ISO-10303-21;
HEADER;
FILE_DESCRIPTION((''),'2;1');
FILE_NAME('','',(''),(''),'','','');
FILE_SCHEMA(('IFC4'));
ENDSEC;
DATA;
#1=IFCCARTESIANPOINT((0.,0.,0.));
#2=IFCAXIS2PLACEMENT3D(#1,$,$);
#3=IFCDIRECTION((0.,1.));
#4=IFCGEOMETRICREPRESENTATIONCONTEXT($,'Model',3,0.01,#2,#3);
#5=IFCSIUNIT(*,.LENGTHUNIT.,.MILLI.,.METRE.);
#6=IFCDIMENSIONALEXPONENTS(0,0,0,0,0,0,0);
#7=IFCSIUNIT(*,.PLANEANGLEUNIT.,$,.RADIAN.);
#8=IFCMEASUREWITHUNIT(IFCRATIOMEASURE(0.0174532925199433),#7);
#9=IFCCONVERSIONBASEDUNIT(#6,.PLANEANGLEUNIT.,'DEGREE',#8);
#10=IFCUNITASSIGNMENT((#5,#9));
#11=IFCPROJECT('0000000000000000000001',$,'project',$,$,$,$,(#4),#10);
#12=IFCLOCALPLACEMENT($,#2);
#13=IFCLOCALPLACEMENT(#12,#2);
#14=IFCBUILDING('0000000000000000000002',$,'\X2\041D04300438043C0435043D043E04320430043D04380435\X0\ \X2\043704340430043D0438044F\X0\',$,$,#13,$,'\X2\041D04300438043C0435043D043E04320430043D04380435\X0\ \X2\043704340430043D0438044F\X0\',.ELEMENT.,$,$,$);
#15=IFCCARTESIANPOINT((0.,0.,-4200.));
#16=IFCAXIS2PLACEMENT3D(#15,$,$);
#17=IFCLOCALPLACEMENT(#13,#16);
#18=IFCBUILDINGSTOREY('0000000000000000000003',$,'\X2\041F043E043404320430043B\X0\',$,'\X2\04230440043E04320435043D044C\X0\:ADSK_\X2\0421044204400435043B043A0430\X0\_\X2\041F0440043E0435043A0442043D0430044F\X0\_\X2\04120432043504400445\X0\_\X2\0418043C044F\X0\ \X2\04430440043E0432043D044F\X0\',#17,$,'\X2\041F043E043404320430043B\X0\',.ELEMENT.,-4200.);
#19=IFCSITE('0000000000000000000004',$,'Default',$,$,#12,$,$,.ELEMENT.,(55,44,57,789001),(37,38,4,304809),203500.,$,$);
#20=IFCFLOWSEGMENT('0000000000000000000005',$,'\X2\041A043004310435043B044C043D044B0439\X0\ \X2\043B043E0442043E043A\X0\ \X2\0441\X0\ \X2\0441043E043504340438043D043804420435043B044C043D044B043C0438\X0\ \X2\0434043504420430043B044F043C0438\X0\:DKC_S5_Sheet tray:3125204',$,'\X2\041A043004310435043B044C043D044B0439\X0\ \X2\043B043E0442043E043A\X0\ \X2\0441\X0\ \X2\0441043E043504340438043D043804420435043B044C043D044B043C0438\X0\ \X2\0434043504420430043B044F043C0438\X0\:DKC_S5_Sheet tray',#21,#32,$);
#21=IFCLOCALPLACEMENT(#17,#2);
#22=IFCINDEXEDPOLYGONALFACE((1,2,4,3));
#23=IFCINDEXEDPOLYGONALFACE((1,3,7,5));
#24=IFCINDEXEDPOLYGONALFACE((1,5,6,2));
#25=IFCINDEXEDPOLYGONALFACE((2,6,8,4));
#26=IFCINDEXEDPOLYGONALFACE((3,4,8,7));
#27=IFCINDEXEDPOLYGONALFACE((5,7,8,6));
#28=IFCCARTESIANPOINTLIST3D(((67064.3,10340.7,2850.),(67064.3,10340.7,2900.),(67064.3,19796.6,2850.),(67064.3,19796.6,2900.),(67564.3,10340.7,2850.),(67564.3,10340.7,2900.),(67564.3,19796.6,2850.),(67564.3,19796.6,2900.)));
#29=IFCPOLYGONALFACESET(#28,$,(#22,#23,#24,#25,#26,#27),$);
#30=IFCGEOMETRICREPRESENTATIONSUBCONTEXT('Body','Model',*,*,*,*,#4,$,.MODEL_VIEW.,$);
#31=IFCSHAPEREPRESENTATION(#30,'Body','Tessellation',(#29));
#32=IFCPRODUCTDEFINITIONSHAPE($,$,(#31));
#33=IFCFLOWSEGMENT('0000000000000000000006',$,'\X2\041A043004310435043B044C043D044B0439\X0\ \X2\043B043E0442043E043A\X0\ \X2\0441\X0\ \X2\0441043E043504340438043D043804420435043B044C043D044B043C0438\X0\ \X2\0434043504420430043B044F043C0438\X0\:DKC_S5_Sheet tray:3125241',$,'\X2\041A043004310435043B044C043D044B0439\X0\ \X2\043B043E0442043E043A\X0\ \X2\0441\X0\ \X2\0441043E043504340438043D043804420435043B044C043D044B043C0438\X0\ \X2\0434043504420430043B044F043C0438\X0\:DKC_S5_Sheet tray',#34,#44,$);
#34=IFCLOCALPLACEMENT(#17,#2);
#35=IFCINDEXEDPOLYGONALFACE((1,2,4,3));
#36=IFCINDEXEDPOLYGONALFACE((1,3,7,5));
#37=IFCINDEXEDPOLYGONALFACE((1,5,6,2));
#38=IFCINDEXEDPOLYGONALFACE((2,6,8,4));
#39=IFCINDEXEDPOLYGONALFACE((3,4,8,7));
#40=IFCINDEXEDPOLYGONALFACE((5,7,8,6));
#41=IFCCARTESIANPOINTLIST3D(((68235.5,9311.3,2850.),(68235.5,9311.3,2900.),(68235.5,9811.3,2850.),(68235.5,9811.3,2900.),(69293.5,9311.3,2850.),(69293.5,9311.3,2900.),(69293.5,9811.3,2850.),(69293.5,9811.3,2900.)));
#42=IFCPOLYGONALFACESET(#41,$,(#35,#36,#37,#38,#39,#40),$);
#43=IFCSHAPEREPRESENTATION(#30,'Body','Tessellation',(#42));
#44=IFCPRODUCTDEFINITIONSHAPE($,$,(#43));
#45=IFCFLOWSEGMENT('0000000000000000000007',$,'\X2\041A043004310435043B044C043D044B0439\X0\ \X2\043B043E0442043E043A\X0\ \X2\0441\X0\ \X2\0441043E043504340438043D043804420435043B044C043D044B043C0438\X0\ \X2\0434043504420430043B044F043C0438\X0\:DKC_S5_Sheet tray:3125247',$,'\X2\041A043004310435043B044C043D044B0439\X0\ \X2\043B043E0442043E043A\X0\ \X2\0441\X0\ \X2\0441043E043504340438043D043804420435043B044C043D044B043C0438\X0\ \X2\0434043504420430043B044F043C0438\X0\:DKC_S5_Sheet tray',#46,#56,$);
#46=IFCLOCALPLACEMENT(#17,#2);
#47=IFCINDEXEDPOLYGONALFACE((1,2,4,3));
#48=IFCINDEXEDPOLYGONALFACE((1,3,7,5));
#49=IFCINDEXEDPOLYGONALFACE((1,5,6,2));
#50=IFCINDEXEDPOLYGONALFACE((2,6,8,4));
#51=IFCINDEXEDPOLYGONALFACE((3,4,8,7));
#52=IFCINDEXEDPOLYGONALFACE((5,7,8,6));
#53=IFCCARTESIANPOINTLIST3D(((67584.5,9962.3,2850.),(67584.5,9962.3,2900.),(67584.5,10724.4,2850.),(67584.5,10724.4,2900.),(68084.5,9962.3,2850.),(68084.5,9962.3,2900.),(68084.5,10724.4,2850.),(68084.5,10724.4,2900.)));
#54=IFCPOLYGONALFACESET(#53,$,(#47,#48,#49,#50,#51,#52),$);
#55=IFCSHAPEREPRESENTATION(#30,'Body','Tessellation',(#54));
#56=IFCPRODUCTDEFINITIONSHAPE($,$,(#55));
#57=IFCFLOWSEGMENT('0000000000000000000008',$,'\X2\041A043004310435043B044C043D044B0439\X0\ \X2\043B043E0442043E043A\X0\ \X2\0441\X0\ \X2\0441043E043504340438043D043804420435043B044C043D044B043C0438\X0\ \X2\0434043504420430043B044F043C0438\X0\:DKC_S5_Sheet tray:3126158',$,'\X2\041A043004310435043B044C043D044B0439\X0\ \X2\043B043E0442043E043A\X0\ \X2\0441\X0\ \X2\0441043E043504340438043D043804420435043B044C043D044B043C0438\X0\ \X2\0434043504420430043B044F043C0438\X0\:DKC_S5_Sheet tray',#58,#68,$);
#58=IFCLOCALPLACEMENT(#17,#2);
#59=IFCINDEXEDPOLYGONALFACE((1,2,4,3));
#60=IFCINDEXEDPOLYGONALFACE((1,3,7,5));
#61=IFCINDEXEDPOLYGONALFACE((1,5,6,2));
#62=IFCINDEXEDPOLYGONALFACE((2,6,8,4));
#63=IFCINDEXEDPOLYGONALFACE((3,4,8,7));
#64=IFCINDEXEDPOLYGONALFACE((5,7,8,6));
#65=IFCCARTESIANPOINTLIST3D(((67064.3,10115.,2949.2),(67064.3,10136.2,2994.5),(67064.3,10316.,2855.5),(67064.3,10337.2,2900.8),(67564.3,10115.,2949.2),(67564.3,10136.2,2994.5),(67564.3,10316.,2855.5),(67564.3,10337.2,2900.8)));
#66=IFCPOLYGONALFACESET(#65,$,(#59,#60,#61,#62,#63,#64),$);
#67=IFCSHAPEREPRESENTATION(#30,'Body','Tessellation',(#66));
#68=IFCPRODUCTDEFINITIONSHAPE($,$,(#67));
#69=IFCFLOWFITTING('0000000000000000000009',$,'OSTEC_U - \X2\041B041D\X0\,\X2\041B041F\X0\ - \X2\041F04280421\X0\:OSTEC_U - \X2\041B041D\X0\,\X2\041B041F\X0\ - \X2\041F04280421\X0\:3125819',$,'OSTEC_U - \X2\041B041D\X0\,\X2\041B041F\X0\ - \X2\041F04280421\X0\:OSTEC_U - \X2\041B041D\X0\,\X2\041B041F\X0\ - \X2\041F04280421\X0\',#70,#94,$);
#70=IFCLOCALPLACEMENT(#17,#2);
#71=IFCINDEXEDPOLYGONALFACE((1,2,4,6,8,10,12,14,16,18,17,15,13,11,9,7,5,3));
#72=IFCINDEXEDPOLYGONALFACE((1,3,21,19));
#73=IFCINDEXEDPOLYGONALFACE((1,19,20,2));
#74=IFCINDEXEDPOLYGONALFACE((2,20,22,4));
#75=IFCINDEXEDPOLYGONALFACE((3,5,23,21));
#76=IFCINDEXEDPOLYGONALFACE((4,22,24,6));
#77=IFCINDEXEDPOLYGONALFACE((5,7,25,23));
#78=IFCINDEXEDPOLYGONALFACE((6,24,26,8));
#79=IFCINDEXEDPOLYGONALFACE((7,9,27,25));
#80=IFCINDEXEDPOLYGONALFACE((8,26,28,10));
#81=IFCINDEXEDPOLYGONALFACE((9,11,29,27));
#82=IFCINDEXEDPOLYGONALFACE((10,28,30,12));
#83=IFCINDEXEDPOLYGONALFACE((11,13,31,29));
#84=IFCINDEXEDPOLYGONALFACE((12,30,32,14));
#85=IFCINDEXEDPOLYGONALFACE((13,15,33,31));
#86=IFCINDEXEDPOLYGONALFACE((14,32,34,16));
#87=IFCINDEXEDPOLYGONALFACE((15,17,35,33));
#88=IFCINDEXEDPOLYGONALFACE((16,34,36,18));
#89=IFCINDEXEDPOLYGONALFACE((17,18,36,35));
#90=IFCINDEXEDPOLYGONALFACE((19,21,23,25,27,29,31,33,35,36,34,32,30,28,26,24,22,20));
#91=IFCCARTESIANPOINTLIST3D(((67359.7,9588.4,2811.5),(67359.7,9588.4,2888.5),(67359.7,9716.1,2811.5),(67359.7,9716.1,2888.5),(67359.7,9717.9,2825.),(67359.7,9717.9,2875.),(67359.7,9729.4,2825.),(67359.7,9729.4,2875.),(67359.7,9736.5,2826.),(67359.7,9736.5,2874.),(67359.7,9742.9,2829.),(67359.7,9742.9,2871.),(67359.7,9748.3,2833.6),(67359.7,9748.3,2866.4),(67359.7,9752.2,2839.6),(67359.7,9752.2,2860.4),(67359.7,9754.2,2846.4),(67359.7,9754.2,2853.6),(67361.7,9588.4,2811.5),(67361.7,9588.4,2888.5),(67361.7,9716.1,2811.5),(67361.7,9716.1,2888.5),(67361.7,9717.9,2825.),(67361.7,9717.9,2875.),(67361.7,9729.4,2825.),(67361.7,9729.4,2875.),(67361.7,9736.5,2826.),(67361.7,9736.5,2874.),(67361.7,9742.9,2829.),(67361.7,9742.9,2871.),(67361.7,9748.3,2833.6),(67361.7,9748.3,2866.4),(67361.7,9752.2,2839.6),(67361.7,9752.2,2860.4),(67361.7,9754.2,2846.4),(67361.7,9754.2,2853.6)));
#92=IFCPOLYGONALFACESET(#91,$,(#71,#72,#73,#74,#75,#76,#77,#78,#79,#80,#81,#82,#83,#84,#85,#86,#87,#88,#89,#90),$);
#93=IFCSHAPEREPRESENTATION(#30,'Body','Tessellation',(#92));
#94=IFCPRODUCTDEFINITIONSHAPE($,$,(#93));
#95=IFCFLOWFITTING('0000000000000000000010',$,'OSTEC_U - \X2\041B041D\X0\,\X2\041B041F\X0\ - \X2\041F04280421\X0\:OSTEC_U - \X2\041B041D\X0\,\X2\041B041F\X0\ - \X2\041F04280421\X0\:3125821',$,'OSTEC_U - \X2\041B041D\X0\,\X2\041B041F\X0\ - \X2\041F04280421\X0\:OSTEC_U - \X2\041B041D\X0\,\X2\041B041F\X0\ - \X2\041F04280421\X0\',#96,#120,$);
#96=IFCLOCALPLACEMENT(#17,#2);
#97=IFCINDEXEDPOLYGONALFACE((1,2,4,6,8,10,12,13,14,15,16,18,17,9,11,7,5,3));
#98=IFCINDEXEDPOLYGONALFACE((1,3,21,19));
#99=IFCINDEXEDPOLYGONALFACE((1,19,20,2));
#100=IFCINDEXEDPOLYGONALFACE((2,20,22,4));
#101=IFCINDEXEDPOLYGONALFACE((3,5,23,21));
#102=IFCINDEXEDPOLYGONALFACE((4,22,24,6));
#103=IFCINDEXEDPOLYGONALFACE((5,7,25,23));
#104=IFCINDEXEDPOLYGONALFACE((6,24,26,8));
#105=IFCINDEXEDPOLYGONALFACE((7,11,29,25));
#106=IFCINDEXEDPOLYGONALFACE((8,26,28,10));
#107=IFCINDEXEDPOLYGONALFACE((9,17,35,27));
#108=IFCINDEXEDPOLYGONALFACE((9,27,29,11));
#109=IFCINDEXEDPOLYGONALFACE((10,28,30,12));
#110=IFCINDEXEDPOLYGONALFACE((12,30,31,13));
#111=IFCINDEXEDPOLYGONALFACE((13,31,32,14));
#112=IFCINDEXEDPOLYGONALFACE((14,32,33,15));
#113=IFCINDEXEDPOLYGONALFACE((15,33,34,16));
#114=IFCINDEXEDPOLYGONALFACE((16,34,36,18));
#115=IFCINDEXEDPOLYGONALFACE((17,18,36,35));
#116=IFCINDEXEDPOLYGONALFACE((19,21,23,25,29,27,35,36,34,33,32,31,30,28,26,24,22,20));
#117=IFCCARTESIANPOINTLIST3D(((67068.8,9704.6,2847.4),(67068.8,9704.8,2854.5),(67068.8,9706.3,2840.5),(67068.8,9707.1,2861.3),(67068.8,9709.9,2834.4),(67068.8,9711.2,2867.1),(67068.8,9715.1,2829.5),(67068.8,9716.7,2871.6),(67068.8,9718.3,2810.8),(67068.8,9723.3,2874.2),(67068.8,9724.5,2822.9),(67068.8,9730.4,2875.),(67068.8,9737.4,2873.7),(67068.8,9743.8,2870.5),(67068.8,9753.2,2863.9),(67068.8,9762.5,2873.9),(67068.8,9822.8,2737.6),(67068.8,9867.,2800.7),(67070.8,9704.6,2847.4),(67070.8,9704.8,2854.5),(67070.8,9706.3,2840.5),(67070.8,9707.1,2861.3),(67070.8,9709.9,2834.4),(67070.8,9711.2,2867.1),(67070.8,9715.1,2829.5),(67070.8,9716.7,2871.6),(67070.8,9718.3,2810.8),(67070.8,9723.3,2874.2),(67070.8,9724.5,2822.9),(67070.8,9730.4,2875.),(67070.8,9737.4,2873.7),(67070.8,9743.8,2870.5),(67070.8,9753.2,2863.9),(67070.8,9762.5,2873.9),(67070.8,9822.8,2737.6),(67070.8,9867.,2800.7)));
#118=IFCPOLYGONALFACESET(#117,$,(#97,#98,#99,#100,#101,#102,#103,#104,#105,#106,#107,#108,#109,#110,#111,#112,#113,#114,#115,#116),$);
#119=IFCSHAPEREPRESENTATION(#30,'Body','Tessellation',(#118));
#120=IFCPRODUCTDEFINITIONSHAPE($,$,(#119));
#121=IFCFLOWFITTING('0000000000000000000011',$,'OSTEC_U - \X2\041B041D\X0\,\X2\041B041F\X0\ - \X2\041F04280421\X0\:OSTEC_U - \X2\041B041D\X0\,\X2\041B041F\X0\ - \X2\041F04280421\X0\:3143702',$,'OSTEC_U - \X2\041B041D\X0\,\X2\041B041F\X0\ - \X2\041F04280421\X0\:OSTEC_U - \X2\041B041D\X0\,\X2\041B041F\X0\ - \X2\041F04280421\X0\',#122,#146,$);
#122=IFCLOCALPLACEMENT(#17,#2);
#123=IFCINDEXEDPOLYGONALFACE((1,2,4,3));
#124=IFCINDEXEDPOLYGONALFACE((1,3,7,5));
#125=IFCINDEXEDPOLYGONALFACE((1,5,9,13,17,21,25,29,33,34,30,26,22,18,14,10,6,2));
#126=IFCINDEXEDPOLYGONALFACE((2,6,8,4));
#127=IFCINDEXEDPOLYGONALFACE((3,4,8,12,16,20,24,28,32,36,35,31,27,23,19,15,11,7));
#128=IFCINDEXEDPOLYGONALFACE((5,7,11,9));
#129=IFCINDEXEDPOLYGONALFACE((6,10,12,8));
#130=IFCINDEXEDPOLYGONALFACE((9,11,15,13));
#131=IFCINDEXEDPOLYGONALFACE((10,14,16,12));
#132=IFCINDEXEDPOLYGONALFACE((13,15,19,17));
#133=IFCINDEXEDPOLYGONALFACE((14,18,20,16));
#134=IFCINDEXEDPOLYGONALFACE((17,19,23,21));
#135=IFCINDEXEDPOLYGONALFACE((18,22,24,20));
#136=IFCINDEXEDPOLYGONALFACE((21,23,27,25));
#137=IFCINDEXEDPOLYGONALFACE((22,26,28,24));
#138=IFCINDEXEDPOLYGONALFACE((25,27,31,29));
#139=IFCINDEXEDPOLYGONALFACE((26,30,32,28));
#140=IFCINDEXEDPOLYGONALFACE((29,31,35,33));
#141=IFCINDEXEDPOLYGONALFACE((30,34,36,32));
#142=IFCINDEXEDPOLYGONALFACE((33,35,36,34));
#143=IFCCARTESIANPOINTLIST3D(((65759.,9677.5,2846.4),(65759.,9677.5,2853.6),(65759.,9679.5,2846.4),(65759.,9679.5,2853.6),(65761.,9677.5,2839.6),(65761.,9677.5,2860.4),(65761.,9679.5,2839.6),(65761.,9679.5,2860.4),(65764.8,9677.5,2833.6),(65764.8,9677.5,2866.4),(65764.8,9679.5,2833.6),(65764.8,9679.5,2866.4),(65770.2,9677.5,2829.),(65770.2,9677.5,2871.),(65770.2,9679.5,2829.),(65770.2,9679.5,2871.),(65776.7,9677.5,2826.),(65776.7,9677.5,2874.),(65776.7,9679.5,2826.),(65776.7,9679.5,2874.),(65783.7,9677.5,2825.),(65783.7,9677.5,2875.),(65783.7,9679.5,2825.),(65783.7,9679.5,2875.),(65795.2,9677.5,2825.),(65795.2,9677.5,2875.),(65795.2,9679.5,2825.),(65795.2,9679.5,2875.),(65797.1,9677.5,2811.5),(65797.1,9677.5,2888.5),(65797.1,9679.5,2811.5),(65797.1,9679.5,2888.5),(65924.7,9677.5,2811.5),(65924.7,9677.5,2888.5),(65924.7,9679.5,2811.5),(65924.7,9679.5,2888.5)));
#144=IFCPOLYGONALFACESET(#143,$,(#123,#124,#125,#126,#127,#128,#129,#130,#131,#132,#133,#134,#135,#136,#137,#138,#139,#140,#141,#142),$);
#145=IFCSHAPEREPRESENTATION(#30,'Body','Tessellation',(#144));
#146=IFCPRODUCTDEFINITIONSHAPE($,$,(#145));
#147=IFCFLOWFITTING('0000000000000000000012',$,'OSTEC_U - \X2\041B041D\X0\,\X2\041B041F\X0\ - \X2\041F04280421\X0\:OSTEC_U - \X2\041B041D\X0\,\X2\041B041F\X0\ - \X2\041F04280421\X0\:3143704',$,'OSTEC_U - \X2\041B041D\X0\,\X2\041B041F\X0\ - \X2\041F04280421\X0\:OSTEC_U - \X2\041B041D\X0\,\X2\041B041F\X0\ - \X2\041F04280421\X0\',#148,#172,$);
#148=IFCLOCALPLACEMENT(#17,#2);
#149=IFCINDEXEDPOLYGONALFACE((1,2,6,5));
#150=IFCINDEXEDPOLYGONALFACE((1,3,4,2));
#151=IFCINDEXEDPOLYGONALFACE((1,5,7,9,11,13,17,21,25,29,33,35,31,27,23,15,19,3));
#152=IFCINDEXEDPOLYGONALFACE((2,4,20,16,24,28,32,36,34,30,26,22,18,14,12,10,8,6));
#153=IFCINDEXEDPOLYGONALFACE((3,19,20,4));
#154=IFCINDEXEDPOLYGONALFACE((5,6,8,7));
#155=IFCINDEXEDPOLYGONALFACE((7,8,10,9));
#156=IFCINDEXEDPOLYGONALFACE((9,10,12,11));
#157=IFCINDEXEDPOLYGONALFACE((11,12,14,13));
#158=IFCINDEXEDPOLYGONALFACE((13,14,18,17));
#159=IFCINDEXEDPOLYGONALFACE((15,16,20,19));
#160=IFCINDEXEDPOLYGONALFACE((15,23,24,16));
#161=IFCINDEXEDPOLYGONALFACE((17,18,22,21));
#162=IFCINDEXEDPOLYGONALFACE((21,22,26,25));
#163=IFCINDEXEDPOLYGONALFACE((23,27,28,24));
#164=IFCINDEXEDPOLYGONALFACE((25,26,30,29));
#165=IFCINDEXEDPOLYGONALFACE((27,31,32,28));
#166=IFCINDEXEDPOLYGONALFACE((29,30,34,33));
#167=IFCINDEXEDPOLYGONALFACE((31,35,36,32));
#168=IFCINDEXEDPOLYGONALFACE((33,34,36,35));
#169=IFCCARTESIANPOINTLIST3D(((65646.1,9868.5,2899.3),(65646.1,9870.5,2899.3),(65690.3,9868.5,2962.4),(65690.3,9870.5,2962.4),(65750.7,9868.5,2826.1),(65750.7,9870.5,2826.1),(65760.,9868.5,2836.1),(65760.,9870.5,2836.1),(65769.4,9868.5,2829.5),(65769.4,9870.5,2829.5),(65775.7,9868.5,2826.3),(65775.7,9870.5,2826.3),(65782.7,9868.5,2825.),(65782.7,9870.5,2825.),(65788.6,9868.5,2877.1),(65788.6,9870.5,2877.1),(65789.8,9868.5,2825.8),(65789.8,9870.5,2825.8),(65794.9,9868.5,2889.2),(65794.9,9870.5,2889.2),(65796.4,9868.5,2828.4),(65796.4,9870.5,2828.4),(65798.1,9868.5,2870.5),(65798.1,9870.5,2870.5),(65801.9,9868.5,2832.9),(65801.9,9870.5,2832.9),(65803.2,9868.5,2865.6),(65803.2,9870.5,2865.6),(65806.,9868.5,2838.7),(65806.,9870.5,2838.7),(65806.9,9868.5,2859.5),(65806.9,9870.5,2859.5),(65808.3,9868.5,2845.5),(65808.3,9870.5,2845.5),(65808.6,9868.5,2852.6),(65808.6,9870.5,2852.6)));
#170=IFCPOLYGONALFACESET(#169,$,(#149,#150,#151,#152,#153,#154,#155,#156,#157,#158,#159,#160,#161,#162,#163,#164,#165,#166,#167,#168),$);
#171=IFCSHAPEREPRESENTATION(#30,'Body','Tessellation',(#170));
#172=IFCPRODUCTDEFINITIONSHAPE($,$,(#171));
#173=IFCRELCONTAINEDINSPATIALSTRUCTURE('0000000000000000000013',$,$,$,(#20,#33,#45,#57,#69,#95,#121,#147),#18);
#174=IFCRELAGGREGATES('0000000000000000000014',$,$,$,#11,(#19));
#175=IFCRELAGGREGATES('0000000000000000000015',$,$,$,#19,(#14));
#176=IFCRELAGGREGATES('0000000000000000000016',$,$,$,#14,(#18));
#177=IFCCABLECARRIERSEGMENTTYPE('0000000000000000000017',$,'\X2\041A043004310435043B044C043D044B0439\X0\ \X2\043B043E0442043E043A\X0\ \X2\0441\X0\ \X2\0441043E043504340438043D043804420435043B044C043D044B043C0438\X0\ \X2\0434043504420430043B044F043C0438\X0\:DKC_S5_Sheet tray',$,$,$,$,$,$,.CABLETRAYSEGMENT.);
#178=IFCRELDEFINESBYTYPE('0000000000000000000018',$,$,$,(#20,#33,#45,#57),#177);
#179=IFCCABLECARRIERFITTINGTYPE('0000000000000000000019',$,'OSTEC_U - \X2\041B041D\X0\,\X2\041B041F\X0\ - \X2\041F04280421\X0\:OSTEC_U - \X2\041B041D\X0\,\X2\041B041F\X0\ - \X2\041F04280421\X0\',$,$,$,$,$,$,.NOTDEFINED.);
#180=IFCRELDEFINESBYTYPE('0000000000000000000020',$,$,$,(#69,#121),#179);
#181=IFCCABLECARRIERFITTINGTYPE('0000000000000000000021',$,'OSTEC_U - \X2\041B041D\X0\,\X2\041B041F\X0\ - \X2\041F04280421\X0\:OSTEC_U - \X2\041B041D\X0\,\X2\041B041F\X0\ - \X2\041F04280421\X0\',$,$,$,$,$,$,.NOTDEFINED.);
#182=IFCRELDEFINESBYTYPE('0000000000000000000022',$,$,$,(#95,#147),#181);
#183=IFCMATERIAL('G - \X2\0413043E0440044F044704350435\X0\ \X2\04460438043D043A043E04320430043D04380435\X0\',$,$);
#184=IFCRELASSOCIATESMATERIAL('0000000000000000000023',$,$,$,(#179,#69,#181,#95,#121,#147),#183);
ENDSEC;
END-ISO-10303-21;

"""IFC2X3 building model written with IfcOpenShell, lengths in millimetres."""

from ifc_helpers import new_model, entity, si_unit, converted_unit, direction, frame, frame_2d, origin, origin_2d_with_axis, place, context, subcontext, project, spatial, polyline, circle_curve, parameter, trimmed, segment, composite_curve, rectangle, outline, extrude, source, transform, mapped, material, type_object, type_shapes, element, save


model = new_model("IFC2X3")

# Units and contexts
model_context = context("Model", 3, precision=0.01, world=origin(), true_north=direction((0.0, 1.0)))
body_context = subcontext(model_context, "Body", "Model", "MODEL_VIEW")
ifc_project = project(units=[si_unit("LENGTHUNIT", "METRE", prefix="MILLI"), converted_unit("PLANEANGLEUNIT", "DEGREE", entity("IfcRatioMeasure", 0.0174532925199433), si_unit("PLANEANGLEUNIT", "RADIAN"), dimensions=[0, 0, 0, 0, 0, 0, 0])], contexts=[model_context])

# Site, building, storey
site_placement = place(None, origin())
site = spatial("IfcSite", under=ifc_project, at=site_placement, Name="Default", CompositionType="ELEMENT", RefLatitude=(55, 44, 57, 789001), RefLongitude=(37, 38, 4, 304809), RefElevation=203500.0)
building_placement = place(site_placement, origin())
building = spatial("IfcBuilding", under=site, at=building_placement, Name="Наименование здания", LongName="Наименование здания", CompositionType="ELEMENT")
storey_placement = place(building_placement, frame((0.0, 0.0, -4200.0)))
storey = spatial("IfcBuildingStorey", under=building, at=storey_placement, Name="Подвал", ObjectType="Уровень:ADSK_Стрелка_Проектная_Вверх_Имя уровня", LongName="Подвал", CompositionType="ELEMENT", Elevation=-4200.0)

# Flow segments
cable_carrier_segment_type = type_object("IfcCableCarrierSegmentType", Name="Кабельный лоток с соединительными деталями:DKC_S5_Sheet tray", PredefinedType="CABLETRAYSEGMENT")
flow_segment_1_placement = place(storey_placement, frame((67064.3, 10340.8, 2850.0)))
element("IfcFlowSegment", 1, at=flow_segment_1_placement, inside=storey, type_object=cable_carrier_segment_type, Name="Кабельный лоток с соединительными деталями:DKC_S5_Sheet tray:3125204", ObjectType="Кабельный лоток с соединительными деталями:DKC_S5_Sheet tray", context=body_context, shape_type="SweptSolid", body=[
    extrude(rectangle(XDim=9455.8, YDim=500.0, at=origin_2d_with_axis()), frame((250.0, 4727.9, 0.0), z_axis=(0.0, 0.0, 1.0), x_axis=(0.0, -1.0, 0.0)), (0.0, 0.0, 1.0), 50.0),
])
flow_segment_2_placement = place(storey_placement, frame((68235.5, 9311.3, 2850.0)))
element("IfcFlowSegment", 2, at=flow_segment_2_placement, inside=storey, type_object=cable_carrier_segment_type, Name="Кабельный лоток с соединительными деталями:DKC_S5_Sheet tray:3125241", ObjectType="Кабельный лоток с соединительными деталями:DKC_S5_Sheet tray", context=body_context, shape_type="SweptSolid", body=[
    extrude(rectangle(XDim=1058.0, YDim=500.0, at=origin_2d_with_axis()), frame((529.0, 250.0, 0.0), z_axis=(0.0, 0.0, 1.0), x_axis=(-1.0, 0.0, 0.0)), (0.0, 0.0, 1.0), 50.0),
])
flow_segment_3_placement = place(storey_placement, frame((67584.5, 9962.3, 2850.0)))
element("IfcFlowSegment", 3, at=flow_segment_3_placement, inside=storey, type_object=cable_carrier_segment_type, Name="Кабельный лоток с соединительными деталями:DKC_S5_Sheet tray:3125247", ObjectType="Кабельный лоток с соединительными деталями:DKC_S5_Sheet tray", context=body_context, shape_type="SweptSolid", body=[
    extrude(rectangle(XDim=762.0, YDim=500.0, at=origin_2d_with_axis()), frame((250.0, 381.0, 0.0), z_axis=(0.0, 0.0, 1.0), x_axis=(0.0, 1.0, 0.0)), (0.0, 0.0, 1.0), 50.0),
])
flow_segment_4_placement = place(storey_placement, frame((67064.3, 10115.0, 2855.5)))
element("IfcFlowSegment", 4, at=flow_segment_4_placement, inside=storey, type_object=cable_carrier_segment_type, Name="Кабельный лоток с соединительными деталями:DKC_S5_Sheet tray:3126158", ObjectType="Кабельный лоток с соединительными деталями:DKC_S5_Sheet tray", context=body_context, shape_type="SweptSolid", body=[
    extrude(rectangle(XDim=50.0, YDim=221.8, at=frame_2d((0.0, 0.0), x_axis=(0.0, 1.0))), frame((0.0, 111.1, 69.5), z_axis=(1.0, 0.0, 0.0), x_axis=(0.0, -0.906308, 0.422618)), (0.0, 0.0, 1.0), 500.0),
])

# Flow fittings
ifc_material_1 = material(Name="G - Горячее цинкование")
cable_carrier_fitting_type_1 = type_object("IfcCableCarrierFittingType", Name="OSTEC_U - ЛН,ЛП - ПШС:OSTEC_U - ЛН,ЛП - ПШС", PredefinedType="NOTDEFINED", material=ifc_material_1)
shared_shape_1 = source(origin(), body_context, "Body", "SweptSolid", [
    extrude(outline(composite_curve([segment(trimmed(circle_curve(frame_2d((-41.5, 0.0), x_axis=(1.0, 0.0)), 25.0), [parameter(90.0)], [parameter(270.0)], True, "PARAMETER"), True, "CONTINUOUS"), segment(polyline([(-41.5, -25.0), (-30.0, -25.0)]), True, "CONTINUOUS"), segment(polyline([(-30.0, -25.0), (-28.1, -38.5)]), True, "CONTINUOUS"), segment(polyline([(-28.1, -38.5), (99.5, -38.5)]), True, "CONTINUOUS"), segment(polyline([(99.5, -38.5), (99.5, 38.5)]), True, "CONTINUOUS"), segment(polyline([(99.5, 38.5), (-28.1, 38.5)]), True, "CONTINUOUS"), segment(polyline([(-28.1, 38.5), (-30.0, 25.0)]), True, "CONTINUOUS"), segment(polyline([(-30.0, 25.0), (-41.5, 25.0)]), True, "CONTINUOUS")], self_intersect=False)), frame((41.5, 0.0, 0.0), z_axis=(0.0, 0.0, -1.0), x_axis=(1.0, 0.0, 0.0)), (0.0, 0.0, -1.0), 2.0),
])
type_shapes(cable_carrier_fitting_type_1, [shared_shape_1])
flow_fitting_1_placement = place(storey_placement, frame((67359.7, 9729.4, 2850.0), z_axis=(1.0, 0.0, 0.0), x_axis=(0.0, -1.0, 0.0)))
element("IfcFlowFitting", 5, at=flow_fitting_1_placement, inside=storey, type_object=cable_carrier_fitting_type_1, material=ifc_material_1, Name="OSTEC_U - ЛН,ЛП - ПШС:OSTEC_U - ЛН,ЛП - ПШС:3125819", ObjectType="OSTEC_U - ЛН,ЛП - ПШС:OSTEC_U - ЛН,ЛП - ПШС", context=body_context, shape_type="MappedRepresentation", body=[
    mapped(shared_shape_1, transform((0.0, 0.0, 0.0), scale=1.0)),
])
cable_carrier_fitting_type_2 = type_object("IfcCableCarrierFittingType", Name="OSTEC_U - ЛН,ЛП - ПШС:OSTEC_U - ЛН,ЛП - ПШС", PredefinedType="NOTDEFINED", material=ifc_material_1)
type_shapes(cable_carrier_fitting_type_2, [shared_shape_1])
flow_fitting_2_placement = place(storey_placement, frame((67070.8, 9729.4, 2850.0), z_axis=(-1.0, 0.0, 0.0), x_axis=(0.0, 0.819152, -0.573576)))
element("IfcFlowFitting", 6, at=flow_fitting_2_placement, inside=storey, type_object=cable_carrier_fitting_type_2, material=ifc_material_1, Name="OSTEC_U - ЛН,ЛП - ПШС:OSTEC_U - ЛН,ЛП - ПШС:3125821", ObjectType="OSTEC_U - ЛН,ЛП - ПШС:OSTEC_U - ЛН,ЛП - ПШС", context=body_context, shape_type="MappedRepresentation", body=[
    mapped(shared_shape_1, transform((0.0, 0.0, 0.0), scale=1.0)),
])
flow_fitting_3_placement = place(storey_placement, frame((65783.7, 9679.5, 2850.0), z_axis=(0.0, -1.0, 0.0), x_axis=(1.0, 0.0, 0.0)))
element("IfcFlowFitting", 7, at=flow_fitting_3_placement, inside=storey, type_object=cable_carrier_fitting_type_1, material=ifc_material_1, Name="OSTEC_U - ЛН,ЛП - ПШС:OSTEC_U - ЛН,ЛП - ПШС:3143702", ObjectType="OSTEC_U - ЛН,ЛП - ПШС:OSTEC_U - ЛН,ЛП - ПШС", context=body_context, shape_type="MappedRepresentation", body=[
    mapped(shared_shape_1, transform((0.0, 0.0, 0.0), scale=1.0)),
])
flow_fitting_4_placement = place(storey_placement, frame((65783.7, 9868.5, 2850.0), z_axis=(0.0, 1.0, 0.0), x_axis=(-0.819152, 0.0, 0.573576)))
element("IfcFlowFitting", 8, at=flow_fitting_4_placement, inside=storey, type_object=cable_carrier_fitting_type_2, material=ifc_material_1, Name="OSTEC_U - ЛН,ЛП - ПШС:OSTEC_U - ЛН,ЛП - ПШС:3143704", ObjectType="OSTEC_U - ЛН,ЛП - ПШС:OSTEC_U - ЛН,ЛП - ПШС", context=body_context, shape_type="MappedRepresentation", body=[
    mapped(shared_shape_1, transform((0.0, 0.0, 0.0), scale=1.0)),
])

save(model, "model.ifc")
